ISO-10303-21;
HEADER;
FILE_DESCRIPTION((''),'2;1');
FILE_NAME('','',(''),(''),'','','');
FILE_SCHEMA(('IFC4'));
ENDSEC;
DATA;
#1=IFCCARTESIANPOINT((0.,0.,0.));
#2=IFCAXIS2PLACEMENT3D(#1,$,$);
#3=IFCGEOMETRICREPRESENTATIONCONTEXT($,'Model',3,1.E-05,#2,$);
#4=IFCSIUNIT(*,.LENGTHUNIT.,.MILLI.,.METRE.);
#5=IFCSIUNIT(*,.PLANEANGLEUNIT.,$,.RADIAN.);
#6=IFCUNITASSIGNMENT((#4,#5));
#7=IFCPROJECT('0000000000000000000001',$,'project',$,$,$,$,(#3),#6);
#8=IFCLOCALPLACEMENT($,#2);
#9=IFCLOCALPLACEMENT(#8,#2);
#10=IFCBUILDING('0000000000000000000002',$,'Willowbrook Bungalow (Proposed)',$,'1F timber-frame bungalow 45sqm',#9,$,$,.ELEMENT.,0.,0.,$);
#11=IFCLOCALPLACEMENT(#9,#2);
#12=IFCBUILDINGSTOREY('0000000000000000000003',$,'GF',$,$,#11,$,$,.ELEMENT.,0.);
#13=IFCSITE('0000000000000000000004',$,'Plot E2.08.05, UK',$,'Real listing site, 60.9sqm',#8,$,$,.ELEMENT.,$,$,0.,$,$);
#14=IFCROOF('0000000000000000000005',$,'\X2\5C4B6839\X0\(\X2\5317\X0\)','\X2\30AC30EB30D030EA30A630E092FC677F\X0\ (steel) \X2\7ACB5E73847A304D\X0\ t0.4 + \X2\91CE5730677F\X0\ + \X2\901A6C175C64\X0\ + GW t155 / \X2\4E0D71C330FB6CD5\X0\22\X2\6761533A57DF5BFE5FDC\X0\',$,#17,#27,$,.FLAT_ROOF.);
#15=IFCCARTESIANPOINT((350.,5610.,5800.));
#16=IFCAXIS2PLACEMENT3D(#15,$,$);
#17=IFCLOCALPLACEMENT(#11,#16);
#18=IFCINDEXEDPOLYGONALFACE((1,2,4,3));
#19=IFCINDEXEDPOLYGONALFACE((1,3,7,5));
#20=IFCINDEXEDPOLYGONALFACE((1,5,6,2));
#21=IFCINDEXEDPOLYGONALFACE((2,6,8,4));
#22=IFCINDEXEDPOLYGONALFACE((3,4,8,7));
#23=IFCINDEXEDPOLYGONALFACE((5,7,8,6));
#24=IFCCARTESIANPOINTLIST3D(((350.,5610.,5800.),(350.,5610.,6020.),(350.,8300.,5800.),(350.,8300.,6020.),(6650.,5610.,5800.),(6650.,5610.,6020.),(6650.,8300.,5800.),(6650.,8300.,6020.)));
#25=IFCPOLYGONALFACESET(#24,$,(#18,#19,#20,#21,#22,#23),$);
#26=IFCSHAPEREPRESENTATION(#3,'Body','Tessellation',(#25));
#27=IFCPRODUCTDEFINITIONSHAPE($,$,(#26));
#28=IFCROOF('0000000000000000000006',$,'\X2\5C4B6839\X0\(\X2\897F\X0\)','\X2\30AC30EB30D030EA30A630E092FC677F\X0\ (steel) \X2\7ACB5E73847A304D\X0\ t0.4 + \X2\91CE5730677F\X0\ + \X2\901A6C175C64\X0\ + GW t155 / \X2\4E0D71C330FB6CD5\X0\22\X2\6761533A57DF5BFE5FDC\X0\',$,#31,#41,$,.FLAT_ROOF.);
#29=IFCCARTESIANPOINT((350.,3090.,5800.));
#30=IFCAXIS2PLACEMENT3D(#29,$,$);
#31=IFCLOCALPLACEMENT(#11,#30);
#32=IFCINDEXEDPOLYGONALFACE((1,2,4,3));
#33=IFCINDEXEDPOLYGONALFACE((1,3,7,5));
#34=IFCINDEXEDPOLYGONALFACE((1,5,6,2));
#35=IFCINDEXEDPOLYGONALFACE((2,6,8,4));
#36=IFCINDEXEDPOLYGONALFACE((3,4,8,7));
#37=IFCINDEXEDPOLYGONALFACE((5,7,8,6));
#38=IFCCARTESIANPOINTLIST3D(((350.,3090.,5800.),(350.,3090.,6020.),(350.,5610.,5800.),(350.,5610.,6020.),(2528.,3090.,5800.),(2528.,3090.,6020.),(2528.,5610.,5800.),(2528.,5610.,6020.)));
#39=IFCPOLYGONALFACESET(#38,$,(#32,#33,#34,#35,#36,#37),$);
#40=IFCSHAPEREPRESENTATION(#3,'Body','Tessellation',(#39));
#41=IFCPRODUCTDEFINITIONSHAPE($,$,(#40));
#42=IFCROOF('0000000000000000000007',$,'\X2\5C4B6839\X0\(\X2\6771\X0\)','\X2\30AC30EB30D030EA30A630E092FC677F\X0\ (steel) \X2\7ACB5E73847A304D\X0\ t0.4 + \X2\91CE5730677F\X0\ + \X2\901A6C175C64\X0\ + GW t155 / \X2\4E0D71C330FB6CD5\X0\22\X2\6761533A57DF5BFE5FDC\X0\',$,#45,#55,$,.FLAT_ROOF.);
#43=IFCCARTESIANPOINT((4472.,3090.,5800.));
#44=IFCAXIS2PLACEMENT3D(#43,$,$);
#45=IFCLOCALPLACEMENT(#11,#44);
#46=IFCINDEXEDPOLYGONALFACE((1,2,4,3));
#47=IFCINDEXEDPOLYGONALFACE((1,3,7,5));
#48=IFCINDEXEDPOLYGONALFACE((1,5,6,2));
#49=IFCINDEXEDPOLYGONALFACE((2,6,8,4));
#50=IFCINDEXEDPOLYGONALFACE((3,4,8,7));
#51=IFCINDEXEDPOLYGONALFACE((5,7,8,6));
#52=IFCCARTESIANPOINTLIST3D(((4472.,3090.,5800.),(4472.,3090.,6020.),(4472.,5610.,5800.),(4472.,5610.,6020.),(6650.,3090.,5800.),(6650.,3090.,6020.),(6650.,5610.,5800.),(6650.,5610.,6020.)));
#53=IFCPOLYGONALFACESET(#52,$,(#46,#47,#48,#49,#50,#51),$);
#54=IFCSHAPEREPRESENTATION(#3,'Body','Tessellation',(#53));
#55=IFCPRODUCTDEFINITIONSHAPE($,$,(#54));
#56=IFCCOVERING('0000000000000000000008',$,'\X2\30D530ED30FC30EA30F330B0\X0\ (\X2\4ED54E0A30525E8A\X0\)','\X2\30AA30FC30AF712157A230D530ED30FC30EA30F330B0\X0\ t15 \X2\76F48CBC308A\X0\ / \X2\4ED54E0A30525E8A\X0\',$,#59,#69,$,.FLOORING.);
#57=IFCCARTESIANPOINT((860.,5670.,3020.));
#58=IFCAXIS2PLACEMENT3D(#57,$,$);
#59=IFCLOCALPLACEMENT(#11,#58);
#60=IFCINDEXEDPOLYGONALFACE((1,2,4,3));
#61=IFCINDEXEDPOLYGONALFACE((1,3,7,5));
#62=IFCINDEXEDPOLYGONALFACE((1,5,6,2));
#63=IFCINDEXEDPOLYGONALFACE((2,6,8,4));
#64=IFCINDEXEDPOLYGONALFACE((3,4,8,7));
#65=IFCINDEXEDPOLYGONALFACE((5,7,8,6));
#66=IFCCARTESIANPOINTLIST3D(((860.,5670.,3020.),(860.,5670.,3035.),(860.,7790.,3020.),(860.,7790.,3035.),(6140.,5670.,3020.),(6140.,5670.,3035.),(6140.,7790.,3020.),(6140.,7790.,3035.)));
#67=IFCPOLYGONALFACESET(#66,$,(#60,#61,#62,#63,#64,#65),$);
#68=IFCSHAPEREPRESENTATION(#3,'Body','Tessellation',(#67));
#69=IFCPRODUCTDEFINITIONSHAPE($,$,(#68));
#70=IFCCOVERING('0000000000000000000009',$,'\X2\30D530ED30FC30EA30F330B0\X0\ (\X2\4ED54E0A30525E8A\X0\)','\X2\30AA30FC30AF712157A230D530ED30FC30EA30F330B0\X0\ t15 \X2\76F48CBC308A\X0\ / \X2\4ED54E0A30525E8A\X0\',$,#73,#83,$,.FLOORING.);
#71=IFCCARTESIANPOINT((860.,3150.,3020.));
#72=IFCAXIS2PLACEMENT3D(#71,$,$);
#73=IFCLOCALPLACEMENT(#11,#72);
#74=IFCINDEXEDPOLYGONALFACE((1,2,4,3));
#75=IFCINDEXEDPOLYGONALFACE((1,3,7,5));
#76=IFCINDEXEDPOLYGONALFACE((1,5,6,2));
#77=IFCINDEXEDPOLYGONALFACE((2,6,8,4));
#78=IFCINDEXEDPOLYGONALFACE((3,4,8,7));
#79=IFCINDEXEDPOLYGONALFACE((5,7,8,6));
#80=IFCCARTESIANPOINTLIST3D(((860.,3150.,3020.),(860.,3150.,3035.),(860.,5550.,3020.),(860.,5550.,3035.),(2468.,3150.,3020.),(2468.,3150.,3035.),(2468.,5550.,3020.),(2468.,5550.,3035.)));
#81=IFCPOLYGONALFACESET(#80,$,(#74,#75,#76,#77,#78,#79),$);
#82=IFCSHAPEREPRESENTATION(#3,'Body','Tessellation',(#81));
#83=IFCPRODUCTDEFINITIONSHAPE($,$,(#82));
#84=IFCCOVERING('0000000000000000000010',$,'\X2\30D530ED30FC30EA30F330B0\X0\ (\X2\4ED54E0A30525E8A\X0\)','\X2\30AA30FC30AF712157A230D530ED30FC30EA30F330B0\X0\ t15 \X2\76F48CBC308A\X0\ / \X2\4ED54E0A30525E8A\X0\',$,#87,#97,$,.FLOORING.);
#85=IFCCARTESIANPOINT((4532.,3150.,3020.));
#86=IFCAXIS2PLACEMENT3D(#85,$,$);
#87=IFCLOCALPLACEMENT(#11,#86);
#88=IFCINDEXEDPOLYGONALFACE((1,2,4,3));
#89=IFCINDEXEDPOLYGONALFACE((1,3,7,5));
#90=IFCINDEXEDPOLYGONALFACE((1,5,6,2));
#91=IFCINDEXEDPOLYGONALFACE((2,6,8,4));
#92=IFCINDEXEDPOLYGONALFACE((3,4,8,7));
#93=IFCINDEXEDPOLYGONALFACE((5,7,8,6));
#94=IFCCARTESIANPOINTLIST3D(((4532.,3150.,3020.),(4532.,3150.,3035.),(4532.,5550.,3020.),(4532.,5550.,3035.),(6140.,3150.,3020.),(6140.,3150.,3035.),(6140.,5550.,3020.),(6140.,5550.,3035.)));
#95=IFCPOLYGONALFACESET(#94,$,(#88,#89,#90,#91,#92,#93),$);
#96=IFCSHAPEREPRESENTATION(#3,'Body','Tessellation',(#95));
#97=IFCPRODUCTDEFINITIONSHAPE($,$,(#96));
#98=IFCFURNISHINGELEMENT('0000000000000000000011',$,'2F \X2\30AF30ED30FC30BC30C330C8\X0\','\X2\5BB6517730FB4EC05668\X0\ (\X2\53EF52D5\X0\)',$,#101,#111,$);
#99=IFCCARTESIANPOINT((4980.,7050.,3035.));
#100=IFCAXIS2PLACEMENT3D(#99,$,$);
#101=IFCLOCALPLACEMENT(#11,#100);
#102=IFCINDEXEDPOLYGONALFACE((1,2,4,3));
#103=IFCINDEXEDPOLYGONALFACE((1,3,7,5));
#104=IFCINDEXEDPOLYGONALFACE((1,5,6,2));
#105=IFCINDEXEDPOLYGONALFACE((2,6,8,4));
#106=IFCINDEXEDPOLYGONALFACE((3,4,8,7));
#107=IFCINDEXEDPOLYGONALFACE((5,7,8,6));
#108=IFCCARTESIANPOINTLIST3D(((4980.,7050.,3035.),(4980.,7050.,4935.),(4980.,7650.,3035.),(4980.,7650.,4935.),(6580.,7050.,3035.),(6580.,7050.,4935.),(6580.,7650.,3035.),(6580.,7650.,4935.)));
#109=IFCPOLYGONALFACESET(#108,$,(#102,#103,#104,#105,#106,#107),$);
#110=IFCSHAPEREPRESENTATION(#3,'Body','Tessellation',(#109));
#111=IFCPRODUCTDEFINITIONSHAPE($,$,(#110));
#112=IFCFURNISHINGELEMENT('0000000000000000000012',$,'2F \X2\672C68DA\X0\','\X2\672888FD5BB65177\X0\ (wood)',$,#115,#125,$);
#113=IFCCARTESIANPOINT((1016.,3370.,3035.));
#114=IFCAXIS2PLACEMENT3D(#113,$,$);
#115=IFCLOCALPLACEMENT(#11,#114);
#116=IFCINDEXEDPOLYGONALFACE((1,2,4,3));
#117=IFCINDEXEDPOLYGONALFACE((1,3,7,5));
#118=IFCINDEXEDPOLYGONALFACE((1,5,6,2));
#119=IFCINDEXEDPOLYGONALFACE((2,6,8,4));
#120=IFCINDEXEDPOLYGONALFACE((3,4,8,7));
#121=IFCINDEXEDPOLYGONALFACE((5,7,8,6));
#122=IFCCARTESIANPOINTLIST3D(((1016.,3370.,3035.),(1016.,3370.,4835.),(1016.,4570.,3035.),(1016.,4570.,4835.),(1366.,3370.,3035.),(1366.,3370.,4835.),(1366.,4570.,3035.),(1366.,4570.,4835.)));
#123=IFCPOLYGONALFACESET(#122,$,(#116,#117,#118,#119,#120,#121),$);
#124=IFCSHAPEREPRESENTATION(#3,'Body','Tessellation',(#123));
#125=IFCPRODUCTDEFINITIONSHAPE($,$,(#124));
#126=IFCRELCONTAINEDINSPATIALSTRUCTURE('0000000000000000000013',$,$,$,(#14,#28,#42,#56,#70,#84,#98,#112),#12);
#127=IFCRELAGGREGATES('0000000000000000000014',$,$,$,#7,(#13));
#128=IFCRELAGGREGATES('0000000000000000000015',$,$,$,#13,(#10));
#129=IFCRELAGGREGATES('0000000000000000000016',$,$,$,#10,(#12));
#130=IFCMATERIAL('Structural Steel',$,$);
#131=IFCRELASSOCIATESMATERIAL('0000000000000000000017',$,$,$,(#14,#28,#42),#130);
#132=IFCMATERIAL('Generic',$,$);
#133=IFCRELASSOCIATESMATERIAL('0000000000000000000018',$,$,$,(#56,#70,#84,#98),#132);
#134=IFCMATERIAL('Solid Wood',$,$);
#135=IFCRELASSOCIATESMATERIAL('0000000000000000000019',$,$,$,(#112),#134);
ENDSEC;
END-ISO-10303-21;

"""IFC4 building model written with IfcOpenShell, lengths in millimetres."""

from ifc_helpers import new_model, si_unit, frame, frame_2d, origin, place, context, project, spatial, rectangle, extrude, material, element, save


model = new_model("IFC4")

# Units and contexts
model_context = context("Model", 3, precision=1e-05, world=origin())
ifc_project = project(units=[si_unit("LENGTHUNIT", "METRE", prefix="MILLI"), si_unit("PLANEANGLEUNIT", "RADIAN")], contexts=[model_context])

# Site, building, storey
site_placement = place(None, origin())
site = spatial("IfcSite", under=ifc_project, at=site_placement, Name="Plot E2.08.05, UK", ObjectType="Real listing site, 60.9sqm", CompositionType="ELEMENT", RefElevation=0.0)
building_placement = place(site_placement, origin())
building = spatial("IfcBuilding", under=site, at=building_placement, Name="Willowbrook Bungalow (Proposed)", ObjectType="1F timber-frame bungalow 45sqm", CompositionType="ELEMENT", ElevationOfRefHeight=0.0, ElevationOfTerrain=0.0)
storey_placement = place(building_placement, origin())
storey = spatial("IfcBuildingStorey", under=building, at=storey_placement, Name="GF", CompositionType="ELEMENT", Elevation=0.0)

# Shared definitions
ifc_material_1 = material(Name="Solid Wood")

# Shared definitions
ifc_material_2 = material(Name="Generic")

# Roofs
ifc_material_3 = material(Name="Structural Steel")
for number, where, name in (
    (1, (350.0, 5610.0, 5800.0), "屋根(北)"),
):
    element("IfcRoof", number, at=place(storey_placement, frame(where)), inside=storey, material=ifc_material_3, Name=name, Description="ガルバリウム鋼板 (steel) 立平葺き t0.4 + 野地板 + 通気層 + GW t155 / 不燃・法22条区域対応", PredefinedType="FLAT_ROOF", context=model_context, shape_type="SweptSolid", body=[
        extrude(rectangle(XDim=6300.0, YDim=2690.0, at=frame_2d((3150.0, 1345.0))), frame((350.0, 5610.0, 5800.0)), (0.0, 0.0, 1.0), 220.0),
    ])
roof_1_placement = place(storey_placement, frame((350.0, 3090.0, 5800.0)))
element("IfcRoof", 2, at=roof_1_placement, inside=storey, material=ifc_material_3, Name="屋根(西)", Description="ガルバリウム鋼板 (steel) 立平葺き t0.4 + 野地板 + 通気層 + GW t155 / 不燃・法22条区域対応", PredefinedType="FLAT_ROOF", context=model_context, shape_type="SweptSolid", body=[
    extrude(rectangle(XDim=2178.0, YDim=2520.0, at=frame_2d((1089.0, 1260.0))), frame((350.0, 3090.0, 5800.0)), (0.0, 0.0, 1.0), 220.0),
])
roof_2_placement = place(storey_placement, frame((4472.0, 3090.0, 5800.0)))
element("IfcRoof", 3, at=roof_2_placement, inside=storey, material=ifc_material_3, Name="屋根(東)", Description="ガルバリウム鋼板 (steel) 立平葺き t0.4 + 野地板 + 通気層 + GW t155 / 不燃・法22条区域対応", PredefinedType="FLAT_ROOF", context=model_context, shape_type="SweptSolid", body=[
    extrude(rectangle(XDim=2178.0, YDim=2520.0, at=frame_2d((1089.0, 1260.0))), frame((4472.0, 3090.0, 5800.0)), (0.0, 0.0, 1.0), 220.0),
])

# Coverings
covering_1_placement = place(storey_placement, frame((860.0, 5670.0, 3020.0)))
element("IfcCovering", 4, at=covering_1_placement, inside=storey, material=ifc_material_2, Name="フローリング (仕上げ床)", Description="オーク無垢フローリング t15 直貼り / 仕上げ床", PredefinedType="FLOORING", context=model_context, shape_type="SweptSolid", body=[
    extrude(rectangle(XDim=5280.0, YDim=2120.0, at=frame_2d((2640.0, 1060.0))), frame((860.0, 5670.0, 3020.0)), (0.0, 0.0, 1.0), 15.0),
])
covering_2_placement = place(storey_placement, frame((860.0, 3150.0, 3020.0)))
element("IfcCovering", 5, at=covering_2_placement, inside=storey, material=ifc_material_2, Name="フローリング (仕上げ床)", Description="オーク無垢フローリング t15 直貼り / 仕上げ床", PredefinedType="FLOORING", context=model_context, shape_type="SweptSolid", body=[
    extrude(rectangle(XDim=1608.0, YDim=2400.0, at=frame_2d((804.0, 1200.0))), frame((860.0, 3150.0, 3020.0)), (0.0, 0.0, 1.0), 15.0),
])
covering_3_placement = place(storey_placement, frame((4532.0, 3150.0, 3020.0)))
element("IfcCovering", 6, at=covering_3_placement, inside=storey, material=ifc_material_2, Name="フローリング (仕上げ床)", Description="オーク無垢フローリング t15 直貼り / 仕上げ床", PredefinedType="FLOORING", context=model_context, shape_type="SweptSolid", body=[
    extrude(rectangle(XDim=1608.0, YDim=2400.0, at=frame_2d((804.0, 1200.0))), frame((4532.0, 3150.0, 3020.0)), (0.0, 0.0, 1.0), 15.0),
])

# Furnishing elements
furnishing_1_placement = place(storey_placement, frame((4980.0, 7050.0, 3035.0)))
element("IfcFurnishingElement", 7, at=furnishing_1_placement, inside=storey, material=ifc_material_2, Name="2F クローゼット", Description="家具・什器 (可動)", context=model_context, shape_type="SweptSolid", body=[
    extrude(rectangle(XDim=1600.0, YDim=600.0, at=frame_2d((800.0, 300.0))), frame((4980.0, 7050.0, 3035.0)), (0.0, 0.0, 1.0), 1900.0),
])
furnishing_2_placement = place(storey_placement, frame((1016.0, 3370.0, 3035.0)))
element("IfcFurnishingElement", 8, at=furnishing_2_placement, inside=storey, material=ifc_material_1, Name="2F 本棚", Description="木製家具 (wood)", context=model_context, shape_type="SweptSolid", body=[
    extrude(rectangle(XDim=350.0, YDim=1200.0, at=frame_2d((175.0, 600.0))), frame((1016.0, 3370.0, 3035.0)), (0.0, 0.0, 1.0), 1800.0),
])

save(model, "model.ifc")
